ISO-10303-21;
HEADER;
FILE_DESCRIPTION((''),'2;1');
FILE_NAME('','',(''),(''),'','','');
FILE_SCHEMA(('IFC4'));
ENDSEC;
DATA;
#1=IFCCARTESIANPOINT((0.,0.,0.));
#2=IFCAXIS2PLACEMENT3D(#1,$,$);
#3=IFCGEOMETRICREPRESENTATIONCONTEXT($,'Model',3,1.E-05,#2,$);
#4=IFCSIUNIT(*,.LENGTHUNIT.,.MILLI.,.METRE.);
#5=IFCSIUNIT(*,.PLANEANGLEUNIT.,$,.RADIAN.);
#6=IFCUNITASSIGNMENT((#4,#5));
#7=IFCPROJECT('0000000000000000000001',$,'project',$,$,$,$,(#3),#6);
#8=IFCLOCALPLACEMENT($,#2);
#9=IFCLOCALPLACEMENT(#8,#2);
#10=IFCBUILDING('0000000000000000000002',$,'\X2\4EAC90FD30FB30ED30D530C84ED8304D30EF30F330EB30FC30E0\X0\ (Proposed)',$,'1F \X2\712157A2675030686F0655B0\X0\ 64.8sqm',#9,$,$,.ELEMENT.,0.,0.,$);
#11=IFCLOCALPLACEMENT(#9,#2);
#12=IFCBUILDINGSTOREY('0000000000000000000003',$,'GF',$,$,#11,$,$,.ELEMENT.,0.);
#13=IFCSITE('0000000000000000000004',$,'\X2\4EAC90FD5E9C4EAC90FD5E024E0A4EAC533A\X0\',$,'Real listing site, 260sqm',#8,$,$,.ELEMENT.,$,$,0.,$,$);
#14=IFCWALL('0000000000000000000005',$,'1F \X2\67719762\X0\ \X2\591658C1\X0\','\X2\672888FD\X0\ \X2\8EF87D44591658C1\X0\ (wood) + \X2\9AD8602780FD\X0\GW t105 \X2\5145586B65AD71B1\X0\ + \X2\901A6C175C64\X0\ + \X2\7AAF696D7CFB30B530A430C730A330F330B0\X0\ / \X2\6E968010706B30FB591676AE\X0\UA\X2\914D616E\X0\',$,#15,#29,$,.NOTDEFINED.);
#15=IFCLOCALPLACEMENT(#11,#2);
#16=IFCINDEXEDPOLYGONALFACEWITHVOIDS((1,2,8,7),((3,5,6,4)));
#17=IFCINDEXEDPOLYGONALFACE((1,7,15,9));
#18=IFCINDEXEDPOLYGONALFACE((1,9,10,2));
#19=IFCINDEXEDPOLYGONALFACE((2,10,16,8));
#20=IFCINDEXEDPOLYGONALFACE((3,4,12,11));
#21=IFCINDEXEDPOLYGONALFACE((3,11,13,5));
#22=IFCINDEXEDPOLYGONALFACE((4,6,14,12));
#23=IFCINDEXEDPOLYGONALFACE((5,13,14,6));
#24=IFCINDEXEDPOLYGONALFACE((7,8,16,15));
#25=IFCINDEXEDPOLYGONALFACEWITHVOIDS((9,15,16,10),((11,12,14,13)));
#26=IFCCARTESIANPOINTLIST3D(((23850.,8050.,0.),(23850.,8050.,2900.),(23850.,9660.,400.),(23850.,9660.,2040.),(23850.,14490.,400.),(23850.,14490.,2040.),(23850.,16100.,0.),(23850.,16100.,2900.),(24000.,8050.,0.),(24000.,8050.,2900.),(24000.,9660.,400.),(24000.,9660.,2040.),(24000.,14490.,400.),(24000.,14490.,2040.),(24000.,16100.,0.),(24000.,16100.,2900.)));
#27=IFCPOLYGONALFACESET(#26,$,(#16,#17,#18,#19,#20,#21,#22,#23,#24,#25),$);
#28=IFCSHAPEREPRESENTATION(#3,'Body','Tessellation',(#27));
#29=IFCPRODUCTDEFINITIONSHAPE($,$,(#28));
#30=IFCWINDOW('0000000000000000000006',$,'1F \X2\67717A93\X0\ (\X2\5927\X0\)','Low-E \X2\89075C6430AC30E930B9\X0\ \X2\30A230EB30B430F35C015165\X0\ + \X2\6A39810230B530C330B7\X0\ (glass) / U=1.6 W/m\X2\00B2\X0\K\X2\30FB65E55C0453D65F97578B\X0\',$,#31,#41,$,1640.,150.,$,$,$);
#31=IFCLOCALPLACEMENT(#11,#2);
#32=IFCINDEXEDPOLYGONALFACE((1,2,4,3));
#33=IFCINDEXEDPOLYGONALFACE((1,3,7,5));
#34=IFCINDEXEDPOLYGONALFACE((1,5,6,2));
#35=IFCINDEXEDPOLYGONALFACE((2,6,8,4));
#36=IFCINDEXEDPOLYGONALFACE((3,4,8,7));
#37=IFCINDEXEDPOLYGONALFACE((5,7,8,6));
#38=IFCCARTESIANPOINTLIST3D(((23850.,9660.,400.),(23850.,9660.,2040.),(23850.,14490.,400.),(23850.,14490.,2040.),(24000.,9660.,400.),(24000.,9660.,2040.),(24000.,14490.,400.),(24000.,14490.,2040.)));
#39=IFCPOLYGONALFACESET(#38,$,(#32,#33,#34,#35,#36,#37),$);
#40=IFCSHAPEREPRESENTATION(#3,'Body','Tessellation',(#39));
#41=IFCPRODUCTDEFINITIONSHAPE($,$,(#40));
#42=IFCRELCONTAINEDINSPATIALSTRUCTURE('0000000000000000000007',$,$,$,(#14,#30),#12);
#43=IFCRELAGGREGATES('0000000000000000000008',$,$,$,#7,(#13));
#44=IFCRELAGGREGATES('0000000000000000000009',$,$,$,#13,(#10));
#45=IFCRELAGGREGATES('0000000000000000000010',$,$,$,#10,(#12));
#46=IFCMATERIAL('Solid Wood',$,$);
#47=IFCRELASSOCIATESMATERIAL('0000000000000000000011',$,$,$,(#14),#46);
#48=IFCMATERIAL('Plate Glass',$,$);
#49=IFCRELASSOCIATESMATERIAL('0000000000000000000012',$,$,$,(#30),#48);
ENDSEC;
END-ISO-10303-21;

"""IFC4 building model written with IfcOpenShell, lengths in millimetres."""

from ifc_helpers import new_model, si_unit, frame, frame_2d, origin, place, context, project, spatial, rectangle, extrude, material, element, fill, save


model = new_model("IFC4")

# Units and contexts
model_context = context("Model", 3, precision=1e-05, world=origin())
ifc_project = project(units=[si_unit("LENGTHUNIT", "METRE", prefix="MILLI"), si_unit("PLANEANGLEUNIT", "RADIAN")], contexts=[model_context])

# Site, building, storey
site_placement = place(None, origin())
site = spatial("IfcSite", under=ifc_project, at=site_placement, Name="京都府京都市上京区", ObjectType="Real listing site, 260sqm", CompositionType="ELEMENT", RefElevation=0.0)
building_placement = place(site_placement, origin())
building = spatial("IfcBuilding", under=site, at=building_placement, Name="京都・ロフト付きワンルーム (Proposed)", ObjectType="1F 無垢材と漆喰 64.8sqm", CompositionType="ELEMENT", ElevationOfRefHeight=0.0, ElevationOfTerrain=0.0)
storey_placement = place(building_placement, origin())
storey = spatial("IfcBuildingStorey", under=building, at=storey_placement, Name="GF", CompositionType="ELEMENT", Elevation=0.0)

# Shared definitions
ifc_material_1 = material(Name="Solid Wood")

# Wall, opening, window
wall_1_placement = place(storey_placement, frame((11925.0, 4025.0, 0.0)))
wall_1 = element("IfcWall", 1, at=wall_1_placement, inside=storey, material=ifc_material_1, Name="1F 東面 外壁", Description="木製 軸組外壁 (wood) + 高性能GW t105 充填断熱 + 通気層 + 窯業系サイディング / 準耐火・外皮UA配慮", PredefinedType="NOTDEFINED", context=model_context, shape_type="SweptSolid", body=[
    extrude(rectangle(XDim=150.0, YDim=8050.0, at=frame_2d((75.0, 4025.0))), frame((11925.0, 4025.0, 0.0)), (0.0, 0.0, 1.0), 2900.0),
])
opening_placement = place(storey_placement, frame((11925.0, 4830.0, 200.0)))
opening = element("IfcOpeningElement", 2, at=opening_placement, cuts=wall_1, PredefinedType="NOTDEFINED", context=model_context, shape_type="SweptSolid", body=[
    extrude(rectangle(XDim=150.0, YDim=4830.0, at=frame_2d((75.0, 2415.0))), frame((11925.0, 4830.0, 200.0)), (0.0, 0.0, 1.0), 1640.0),
])
ifc_material_2 = material(Name="Plate Glass")
window_placement = place(storey_placement, frame((11925.0, 4830.0, 200.0)))
window = element("IfcWindow", 3, at=window_placement, inside=storey, material=ifc_material_2, Name="1F 東窓 (大)", Description="Low-E 複層ガラス アルゴン封入 + 樹脂サッシ (glass) / U=1.6 W/m²K・日射取得型", OverallHeight=1640.0, OverallWidth=150.0, context=model_context, shape_type="SweptSolid", body=[
    extrude(rectangle(XDim=150.0, YDim=4830.0, at=frame_2d((75.0, 2415.0))), frame((11925.0, 4830.0, 200.0)), (0.0, 0.0, 1.0), 1640.0),
])
fill(opening, window)

save(model, "model.ifc")
